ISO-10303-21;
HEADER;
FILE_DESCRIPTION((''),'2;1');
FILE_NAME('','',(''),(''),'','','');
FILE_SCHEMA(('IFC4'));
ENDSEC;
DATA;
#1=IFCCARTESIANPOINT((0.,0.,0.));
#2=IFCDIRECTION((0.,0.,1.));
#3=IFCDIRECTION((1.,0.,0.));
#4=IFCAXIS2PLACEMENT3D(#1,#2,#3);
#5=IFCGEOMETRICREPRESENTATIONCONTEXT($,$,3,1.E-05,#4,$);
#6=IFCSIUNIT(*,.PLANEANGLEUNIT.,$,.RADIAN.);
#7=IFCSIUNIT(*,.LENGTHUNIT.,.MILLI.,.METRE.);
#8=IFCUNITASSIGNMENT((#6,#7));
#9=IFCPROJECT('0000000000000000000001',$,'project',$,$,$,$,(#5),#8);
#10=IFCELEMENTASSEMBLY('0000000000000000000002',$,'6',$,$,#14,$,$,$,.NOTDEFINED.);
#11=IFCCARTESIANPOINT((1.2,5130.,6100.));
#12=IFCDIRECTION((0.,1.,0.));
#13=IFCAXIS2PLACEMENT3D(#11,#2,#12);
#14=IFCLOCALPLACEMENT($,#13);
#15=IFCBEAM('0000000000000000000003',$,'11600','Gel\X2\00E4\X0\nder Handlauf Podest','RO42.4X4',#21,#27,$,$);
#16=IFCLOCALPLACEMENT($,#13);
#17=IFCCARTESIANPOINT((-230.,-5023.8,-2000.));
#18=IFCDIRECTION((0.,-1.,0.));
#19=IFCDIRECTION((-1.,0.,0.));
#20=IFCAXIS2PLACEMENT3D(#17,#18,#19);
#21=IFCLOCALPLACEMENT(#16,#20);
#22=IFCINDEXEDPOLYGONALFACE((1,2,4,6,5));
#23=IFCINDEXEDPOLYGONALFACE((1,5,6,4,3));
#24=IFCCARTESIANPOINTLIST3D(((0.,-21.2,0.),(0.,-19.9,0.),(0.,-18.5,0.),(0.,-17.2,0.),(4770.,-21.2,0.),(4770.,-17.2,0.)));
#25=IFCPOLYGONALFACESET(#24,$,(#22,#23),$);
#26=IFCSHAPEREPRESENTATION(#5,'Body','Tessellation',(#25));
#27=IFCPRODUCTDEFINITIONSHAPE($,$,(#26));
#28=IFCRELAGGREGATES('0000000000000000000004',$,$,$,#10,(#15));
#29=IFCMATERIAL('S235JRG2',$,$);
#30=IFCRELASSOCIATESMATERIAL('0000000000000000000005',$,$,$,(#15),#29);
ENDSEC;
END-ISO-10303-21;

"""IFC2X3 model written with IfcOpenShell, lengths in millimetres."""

from ifc_helpers import new_model, si_unit, frame, origin_with_axes, place, context, project, polyline, outline, extrude, material, element, aggregate, save


model = new_model("IFC2X3")

# Units and contexts
context_of_model = context(None, 3, precision=1e-05, world=origin_with_axes())
ifc_project = project(units=[si_unit("PLANEANGLEUNIT", "RADIAN"), si_unit("LENGTHUNIT", "METRE", prefix="MILLI")], contexts=[context_of_model])

# Shared definitions
ifc_material = material(Name="S235JRG2")

# Element assembly, beam
assembly_1_placement = place(None, frame((1.2, 5130.0, 6100.0), z_axis=(0.0, 0.0, 1.0), x_axis=(0.0, 1.0, 0.0)))
assembly_1 = element("IfcElementAssembly", 1, at=assembly_1_placement, Name="6", PredefinedType="NOTDEFINED")
placement_1 = place(None, frame((1.2, 5130.0, 6100.0), z_axis=(0.0, 0.0, 1.0), x_axis=(0.0, 1.0, 0.0)))
beam_1_placement = place(placement_1, frame((-230.0, -5023.8, -2000.0), z_axis=(0.0, -1.0, 0.0), x_axis=(-1.0, 0.0, 0.0)))
beam_1 = element("IfcBeam", 2, at=beam_1_placement, material=ifc_material, Name="11600", Description="Geländer Handlauf Podest", ObjectType="RO42.4X4", context=context_of_model, shape_type="SweptSolid", body=[
    extrude(outline(polyline([(-21.2, 0.0), (-21.2, 0.0), (-17.2, 0.0), (-17.2, 0.0), (-21.2, 0.0)])), frame((0.0, 0.0, 0.0), z_axis=(1.0, 0.0, 0.0), x_axis=(0.0, 1.0, 0.0)), (0.0, 0.0, 1.0), 4770.0),
])
aggregate(assembly_1, [beam_1])

save(model, "model.ifc")
